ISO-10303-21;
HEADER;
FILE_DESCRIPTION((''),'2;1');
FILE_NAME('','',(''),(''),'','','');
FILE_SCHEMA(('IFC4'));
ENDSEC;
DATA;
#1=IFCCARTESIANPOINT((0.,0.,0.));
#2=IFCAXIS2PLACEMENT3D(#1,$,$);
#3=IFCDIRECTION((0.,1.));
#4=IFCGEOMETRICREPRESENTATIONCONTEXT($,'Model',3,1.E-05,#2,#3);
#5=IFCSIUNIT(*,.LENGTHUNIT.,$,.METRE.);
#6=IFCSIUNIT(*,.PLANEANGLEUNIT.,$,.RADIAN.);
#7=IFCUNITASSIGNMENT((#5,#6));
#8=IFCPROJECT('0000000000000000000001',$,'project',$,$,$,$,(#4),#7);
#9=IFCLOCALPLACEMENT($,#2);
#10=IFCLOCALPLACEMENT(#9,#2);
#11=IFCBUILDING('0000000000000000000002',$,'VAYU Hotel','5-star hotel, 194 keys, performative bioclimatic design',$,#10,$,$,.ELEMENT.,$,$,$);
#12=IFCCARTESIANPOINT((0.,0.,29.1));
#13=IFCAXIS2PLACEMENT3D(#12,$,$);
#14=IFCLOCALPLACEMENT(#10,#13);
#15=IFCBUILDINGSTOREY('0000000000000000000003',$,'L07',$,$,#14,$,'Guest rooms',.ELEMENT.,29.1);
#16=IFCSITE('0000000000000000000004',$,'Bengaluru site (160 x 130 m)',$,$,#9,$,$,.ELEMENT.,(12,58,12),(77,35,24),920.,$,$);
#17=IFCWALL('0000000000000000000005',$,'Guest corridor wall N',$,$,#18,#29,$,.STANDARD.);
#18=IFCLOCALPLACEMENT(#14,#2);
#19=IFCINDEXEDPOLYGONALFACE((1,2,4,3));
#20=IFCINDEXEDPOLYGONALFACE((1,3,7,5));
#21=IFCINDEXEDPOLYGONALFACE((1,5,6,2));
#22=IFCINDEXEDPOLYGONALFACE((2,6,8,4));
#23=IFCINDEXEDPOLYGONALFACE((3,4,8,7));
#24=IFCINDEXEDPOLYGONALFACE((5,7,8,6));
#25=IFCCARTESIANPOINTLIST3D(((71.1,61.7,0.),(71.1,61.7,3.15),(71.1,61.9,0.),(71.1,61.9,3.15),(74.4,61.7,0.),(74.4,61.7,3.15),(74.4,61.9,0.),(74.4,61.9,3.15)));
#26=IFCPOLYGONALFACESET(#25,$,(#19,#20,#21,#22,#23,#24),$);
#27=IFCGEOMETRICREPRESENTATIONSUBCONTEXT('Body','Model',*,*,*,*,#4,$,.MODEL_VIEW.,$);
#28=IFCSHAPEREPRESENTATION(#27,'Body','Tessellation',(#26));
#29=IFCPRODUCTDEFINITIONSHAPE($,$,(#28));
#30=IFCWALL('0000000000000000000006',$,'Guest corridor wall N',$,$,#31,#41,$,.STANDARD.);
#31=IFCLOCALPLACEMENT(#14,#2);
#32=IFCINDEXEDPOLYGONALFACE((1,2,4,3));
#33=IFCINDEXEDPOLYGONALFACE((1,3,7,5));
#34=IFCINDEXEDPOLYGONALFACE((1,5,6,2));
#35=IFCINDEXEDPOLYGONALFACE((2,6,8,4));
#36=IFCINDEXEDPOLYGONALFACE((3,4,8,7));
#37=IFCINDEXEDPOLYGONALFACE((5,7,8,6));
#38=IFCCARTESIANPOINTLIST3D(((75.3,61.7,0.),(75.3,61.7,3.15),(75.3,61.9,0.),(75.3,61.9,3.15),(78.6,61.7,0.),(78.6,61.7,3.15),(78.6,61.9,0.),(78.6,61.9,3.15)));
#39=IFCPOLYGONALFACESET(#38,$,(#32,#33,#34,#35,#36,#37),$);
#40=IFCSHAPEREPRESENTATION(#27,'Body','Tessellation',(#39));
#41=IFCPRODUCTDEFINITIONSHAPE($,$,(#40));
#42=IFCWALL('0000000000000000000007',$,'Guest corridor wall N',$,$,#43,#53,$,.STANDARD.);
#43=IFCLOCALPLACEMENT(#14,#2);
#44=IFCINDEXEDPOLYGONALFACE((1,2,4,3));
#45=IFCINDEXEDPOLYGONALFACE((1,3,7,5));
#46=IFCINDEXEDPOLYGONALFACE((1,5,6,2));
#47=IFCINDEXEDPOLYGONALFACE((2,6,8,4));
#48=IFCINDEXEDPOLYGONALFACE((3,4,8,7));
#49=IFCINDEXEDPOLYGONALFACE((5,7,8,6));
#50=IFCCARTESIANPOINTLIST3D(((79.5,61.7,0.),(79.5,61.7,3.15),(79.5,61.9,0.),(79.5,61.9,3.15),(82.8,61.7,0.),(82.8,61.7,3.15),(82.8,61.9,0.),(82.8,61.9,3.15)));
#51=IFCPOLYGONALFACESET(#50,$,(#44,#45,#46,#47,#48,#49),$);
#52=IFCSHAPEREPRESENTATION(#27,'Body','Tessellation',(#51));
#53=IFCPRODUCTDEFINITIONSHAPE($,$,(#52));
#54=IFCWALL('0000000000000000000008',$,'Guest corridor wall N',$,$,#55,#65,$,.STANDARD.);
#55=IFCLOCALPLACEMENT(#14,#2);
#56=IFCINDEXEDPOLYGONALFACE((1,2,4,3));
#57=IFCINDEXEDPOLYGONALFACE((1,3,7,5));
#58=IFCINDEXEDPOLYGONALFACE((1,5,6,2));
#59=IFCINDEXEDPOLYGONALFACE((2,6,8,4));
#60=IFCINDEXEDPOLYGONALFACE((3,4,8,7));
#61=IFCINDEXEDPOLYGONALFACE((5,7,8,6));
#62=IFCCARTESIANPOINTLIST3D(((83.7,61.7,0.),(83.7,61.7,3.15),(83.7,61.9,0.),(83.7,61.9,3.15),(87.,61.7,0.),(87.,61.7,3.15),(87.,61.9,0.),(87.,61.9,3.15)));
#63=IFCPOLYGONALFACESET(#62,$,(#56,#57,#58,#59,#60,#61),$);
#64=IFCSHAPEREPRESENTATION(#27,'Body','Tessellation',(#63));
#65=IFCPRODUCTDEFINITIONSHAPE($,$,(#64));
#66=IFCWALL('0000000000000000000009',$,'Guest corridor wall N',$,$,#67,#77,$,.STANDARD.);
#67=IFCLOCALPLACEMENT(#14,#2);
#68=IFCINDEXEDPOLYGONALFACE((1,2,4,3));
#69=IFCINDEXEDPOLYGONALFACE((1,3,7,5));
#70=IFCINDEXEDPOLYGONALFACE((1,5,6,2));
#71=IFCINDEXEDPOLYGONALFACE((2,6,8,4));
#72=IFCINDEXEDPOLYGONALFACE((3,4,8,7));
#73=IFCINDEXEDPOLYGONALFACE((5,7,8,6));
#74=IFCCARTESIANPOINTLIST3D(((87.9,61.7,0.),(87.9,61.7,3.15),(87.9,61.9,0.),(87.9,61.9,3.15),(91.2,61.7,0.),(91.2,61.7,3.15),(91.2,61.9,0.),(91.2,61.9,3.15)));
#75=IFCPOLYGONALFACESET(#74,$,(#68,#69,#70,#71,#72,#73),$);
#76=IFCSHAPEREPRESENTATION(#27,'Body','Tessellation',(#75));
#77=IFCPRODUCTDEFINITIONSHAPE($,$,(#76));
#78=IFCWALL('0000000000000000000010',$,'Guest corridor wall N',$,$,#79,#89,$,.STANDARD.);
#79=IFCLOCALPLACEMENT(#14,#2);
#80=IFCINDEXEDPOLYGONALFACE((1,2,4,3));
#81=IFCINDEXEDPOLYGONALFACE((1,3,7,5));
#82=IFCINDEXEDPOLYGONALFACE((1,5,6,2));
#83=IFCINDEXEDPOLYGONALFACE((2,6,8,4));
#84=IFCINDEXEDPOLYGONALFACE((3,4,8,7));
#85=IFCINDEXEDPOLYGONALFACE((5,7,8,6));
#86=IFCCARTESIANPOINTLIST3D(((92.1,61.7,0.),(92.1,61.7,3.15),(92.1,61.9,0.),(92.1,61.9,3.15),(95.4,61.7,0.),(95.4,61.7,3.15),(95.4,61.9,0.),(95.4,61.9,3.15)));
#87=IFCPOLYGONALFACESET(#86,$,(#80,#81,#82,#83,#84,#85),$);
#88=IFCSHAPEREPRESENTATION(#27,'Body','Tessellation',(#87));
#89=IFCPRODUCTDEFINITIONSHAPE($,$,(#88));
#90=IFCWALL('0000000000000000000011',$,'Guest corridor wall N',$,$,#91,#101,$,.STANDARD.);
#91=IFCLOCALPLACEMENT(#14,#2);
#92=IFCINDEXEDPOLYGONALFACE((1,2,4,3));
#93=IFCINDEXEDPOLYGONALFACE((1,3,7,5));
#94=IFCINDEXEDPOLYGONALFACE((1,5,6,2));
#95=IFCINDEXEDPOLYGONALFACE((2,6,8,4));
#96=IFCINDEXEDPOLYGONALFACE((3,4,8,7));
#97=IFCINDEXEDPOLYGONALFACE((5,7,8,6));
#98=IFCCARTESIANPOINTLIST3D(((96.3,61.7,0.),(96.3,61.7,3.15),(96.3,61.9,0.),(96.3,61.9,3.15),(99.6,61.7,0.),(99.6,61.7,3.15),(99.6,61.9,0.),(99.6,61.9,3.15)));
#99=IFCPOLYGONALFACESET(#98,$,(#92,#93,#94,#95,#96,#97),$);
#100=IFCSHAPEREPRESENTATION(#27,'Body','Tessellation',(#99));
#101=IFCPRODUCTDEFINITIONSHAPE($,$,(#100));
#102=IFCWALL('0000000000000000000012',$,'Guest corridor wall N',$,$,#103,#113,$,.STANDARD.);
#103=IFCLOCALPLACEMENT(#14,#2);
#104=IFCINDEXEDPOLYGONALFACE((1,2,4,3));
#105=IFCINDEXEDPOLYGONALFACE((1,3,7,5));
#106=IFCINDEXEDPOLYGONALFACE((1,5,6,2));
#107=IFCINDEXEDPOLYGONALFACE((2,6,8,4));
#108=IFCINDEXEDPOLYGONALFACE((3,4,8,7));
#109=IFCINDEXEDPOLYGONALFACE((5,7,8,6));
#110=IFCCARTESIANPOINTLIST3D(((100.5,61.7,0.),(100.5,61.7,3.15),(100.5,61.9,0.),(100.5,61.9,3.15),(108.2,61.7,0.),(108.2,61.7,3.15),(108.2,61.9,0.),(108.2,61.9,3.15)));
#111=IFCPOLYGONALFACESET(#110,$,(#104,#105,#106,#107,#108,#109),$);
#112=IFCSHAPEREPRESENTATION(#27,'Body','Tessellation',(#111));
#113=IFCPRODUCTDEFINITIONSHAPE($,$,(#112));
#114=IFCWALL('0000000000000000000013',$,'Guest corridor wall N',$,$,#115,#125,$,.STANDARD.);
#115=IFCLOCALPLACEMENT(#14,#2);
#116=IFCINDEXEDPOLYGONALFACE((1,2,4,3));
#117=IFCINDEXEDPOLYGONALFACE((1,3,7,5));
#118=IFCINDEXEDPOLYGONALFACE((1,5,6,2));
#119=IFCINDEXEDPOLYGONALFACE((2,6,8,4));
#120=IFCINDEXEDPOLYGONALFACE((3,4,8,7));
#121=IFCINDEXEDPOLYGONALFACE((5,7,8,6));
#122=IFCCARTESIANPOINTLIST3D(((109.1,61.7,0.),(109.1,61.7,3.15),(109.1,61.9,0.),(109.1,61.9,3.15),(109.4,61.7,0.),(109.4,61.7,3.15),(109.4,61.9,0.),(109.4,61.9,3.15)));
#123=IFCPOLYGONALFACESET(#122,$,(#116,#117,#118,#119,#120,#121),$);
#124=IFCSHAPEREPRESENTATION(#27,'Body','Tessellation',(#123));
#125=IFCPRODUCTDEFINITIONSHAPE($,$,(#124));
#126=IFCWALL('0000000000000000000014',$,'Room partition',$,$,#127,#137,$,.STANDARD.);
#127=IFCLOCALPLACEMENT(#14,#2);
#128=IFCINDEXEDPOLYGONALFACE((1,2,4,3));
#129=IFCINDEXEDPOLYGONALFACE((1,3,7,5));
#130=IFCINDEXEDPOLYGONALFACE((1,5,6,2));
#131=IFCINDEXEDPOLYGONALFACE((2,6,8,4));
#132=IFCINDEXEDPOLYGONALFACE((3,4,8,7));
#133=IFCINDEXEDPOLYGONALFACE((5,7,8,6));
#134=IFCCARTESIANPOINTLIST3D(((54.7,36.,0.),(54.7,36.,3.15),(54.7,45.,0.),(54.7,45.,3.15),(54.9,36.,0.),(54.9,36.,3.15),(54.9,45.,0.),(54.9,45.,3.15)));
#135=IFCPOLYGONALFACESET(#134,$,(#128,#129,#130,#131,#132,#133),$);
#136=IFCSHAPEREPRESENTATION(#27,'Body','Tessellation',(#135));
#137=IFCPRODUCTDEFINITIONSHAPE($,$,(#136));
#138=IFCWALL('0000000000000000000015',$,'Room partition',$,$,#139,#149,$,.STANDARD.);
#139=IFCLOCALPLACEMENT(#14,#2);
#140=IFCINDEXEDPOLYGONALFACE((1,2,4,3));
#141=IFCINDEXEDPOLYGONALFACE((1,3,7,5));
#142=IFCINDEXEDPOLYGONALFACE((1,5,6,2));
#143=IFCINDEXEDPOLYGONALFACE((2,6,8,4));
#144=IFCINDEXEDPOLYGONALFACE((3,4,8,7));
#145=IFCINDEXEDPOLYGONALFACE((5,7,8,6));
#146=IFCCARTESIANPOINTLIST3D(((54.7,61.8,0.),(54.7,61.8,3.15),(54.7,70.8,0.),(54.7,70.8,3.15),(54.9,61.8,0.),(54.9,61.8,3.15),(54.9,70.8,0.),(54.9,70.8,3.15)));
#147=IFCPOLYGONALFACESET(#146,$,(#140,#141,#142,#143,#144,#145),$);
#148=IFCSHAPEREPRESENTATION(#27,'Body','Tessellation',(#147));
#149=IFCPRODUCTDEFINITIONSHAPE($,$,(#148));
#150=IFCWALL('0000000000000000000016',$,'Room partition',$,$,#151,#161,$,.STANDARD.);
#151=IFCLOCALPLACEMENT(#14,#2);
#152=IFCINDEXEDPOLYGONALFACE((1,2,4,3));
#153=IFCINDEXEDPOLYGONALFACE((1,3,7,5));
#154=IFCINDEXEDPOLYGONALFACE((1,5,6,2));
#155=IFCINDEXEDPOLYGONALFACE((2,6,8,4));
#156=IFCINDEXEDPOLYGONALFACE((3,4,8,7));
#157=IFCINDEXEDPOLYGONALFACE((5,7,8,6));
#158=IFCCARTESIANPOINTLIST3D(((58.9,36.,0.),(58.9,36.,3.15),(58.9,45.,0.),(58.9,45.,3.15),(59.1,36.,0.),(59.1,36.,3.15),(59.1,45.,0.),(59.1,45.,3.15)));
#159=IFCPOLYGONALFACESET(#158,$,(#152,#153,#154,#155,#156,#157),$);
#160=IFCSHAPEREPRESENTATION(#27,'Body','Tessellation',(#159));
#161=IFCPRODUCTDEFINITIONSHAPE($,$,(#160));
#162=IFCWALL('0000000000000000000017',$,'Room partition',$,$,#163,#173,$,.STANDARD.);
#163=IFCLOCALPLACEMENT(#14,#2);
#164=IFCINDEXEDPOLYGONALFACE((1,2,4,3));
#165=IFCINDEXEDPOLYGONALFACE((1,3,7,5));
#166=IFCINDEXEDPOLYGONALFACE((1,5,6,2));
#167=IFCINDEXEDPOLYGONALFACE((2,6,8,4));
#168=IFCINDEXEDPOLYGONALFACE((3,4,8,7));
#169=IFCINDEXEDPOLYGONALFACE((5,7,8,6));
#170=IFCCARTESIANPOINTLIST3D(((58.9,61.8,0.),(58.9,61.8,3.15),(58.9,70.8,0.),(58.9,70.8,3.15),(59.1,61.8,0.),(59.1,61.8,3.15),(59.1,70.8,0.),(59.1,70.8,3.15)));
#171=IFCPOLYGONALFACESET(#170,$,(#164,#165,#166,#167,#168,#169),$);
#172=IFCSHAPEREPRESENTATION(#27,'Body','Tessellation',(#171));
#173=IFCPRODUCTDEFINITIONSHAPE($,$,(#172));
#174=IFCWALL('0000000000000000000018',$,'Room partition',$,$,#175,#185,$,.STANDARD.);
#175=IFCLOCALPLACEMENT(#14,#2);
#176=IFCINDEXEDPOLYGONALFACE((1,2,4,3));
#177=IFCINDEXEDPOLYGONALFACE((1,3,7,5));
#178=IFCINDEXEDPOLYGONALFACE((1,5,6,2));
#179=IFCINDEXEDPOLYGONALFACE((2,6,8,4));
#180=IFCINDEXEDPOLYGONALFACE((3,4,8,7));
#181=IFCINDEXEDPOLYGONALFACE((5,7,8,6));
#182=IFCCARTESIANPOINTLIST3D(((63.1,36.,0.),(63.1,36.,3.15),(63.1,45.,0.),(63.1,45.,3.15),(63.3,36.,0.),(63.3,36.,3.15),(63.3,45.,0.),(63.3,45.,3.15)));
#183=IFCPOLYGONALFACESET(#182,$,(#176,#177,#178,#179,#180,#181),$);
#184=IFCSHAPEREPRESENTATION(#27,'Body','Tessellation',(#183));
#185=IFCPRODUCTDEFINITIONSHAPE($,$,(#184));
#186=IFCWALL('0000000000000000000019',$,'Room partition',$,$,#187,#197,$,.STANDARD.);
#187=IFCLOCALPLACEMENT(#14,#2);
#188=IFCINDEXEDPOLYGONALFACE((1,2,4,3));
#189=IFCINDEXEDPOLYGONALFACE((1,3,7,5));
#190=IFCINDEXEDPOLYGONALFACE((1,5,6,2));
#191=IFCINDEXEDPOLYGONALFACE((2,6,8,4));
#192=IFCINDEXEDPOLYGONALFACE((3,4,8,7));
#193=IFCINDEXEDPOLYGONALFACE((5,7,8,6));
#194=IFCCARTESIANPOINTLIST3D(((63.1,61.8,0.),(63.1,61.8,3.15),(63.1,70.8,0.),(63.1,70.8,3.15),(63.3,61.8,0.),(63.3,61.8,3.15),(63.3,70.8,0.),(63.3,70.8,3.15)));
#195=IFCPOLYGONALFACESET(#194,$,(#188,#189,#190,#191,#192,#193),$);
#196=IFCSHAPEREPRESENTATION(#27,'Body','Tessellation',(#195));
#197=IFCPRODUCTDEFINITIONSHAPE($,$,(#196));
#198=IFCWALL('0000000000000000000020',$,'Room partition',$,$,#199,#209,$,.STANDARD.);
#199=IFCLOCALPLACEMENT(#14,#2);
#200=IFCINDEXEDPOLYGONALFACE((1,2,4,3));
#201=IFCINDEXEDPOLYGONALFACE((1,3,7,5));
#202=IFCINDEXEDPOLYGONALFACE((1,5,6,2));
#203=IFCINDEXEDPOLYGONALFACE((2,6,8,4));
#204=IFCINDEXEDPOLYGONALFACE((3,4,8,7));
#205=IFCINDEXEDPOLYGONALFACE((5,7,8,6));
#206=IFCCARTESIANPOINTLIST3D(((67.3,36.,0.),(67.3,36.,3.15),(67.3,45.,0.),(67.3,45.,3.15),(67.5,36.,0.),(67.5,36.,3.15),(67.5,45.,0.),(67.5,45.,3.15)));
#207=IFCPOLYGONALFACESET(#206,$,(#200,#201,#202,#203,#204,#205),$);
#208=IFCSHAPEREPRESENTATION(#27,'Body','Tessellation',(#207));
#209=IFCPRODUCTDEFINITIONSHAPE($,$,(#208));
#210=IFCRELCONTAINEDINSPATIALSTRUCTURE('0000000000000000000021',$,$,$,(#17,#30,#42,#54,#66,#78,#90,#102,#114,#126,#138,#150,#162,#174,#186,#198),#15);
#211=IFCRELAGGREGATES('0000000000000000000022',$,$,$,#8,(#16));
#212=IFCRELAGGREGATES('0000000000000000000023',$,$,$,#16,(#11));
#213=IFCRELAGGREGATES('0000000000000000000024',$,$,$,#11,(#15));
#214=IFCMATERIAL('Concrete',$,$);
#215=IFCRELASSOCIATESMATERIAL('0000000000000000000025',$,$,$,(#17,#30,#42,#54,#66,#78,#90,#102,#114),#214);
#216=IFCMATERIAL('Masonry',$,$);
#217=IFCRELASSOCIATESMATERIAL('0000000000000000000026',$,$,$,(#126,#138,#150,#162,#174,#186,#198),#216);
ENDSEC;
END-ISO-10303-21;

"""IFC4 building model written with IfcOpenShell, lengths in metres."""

from ifc_helpers import new_model, si_unit, direction, frame, origin, place, context, subcontext, project, spatial, polyline, outline, extrude, material, element, save


model = new_model("IFC4")

# Units and contexts
model_context = context("Model", 3, precision=1e-05, world=origin(), true_north=direction((0.0, 1.0)))
body_context = subcontext(model_context, "Body", "Model", "MODEL_VIEW")
ifc_project = project(units=[si_unit("LENGTHUNIT", "METRE"), si_unit("PLANEANGLEUNIT", "RADIAN")], contexts=[model_context])

# Site, building, storey
site_placement = place(None, origin())
site = spatial("IfcSite", under=ifc_project, at=site_placement, Name="Bengaluru site (160 x 130 m)", CompositionType="ELEMENT", RefLatitude=(12, 58, 12), RefLongitude=(77, 35, 24), RefElevation=920.0)
building_placement = place(site_placement, origin())
building = spatial("IfcBuilding", under=site, at=building_placement, Name="VAYU Hotel", Description="5-star hotel, 194 keys, performative bioclimatic design", CompositionType="ELEMENT")
storey_placement = place(building_placement, frame((0.0, 0.0, 29.1)))
storey = spatial("IfcBuildingStorey", under=building, at=storey_placement, Name="L07", LongName="Guest rooms", CompositionType="ELEMENT", Elevation=29.1)

# Walls
ifc_material_1 = material(Name="Concrete")
wall_1_placement = place(storey_placement, origin())
element("IfcWall", 1, at=wall_1_placement, inside=storey, material=ifc_material_1, Name="Guest corridor wall N", PredefinedType="STANDARD", context=body_context, shape_type="SweptSolid", body=[
    extrude(outline(polyline([(71.1, 61.9), (74.4, 61.9), (74.4, 61.7), (71.1, 61.7), (71.1, 61.9)])), origin(), (0.0, 0.0, 1.0), 3.15),
])
wall_2_placement = place(storey_placement, origin())
element("IfcWall", 2, at=wall_2_placement, inside=storey, material=ifc_material_1, Name="Guest corridor wall N", PredefinedType="STANDARD", context=body_context, shape_type="SweptSolid", body=[
    extrude(outline(polyline([(75.3, 61.9), (78.6, 61.9), (78.6, 61.7), (75.3, 61.7), (75.3, 61.9)])), origin(), (0.0, 0.0, 1.0), 3.15),
])
wall_3_placement = place(storey_placement, origin())
element("IfcWall", 3, at=wall_3_placement, inside=storey, material=ifc_material_1, Name="Guest corridor wall N", PredefinedType="STANDARD", context=body_context, shape_type="SweptSolid", body=[
    extrude(outline(polyline([(79.5, 61.9), (82.8, 61.9), (82.8, 61.7), (79.5, 61.7), (79.5, 61.9)])), origin(), (0.0, 0.0, 1.0), 3.15),
])
wall_4_placement = place(storey_placement, origin())
element("IfcWall", 4, at=wall_4_placement, inside=storey, material=ifc_material_1, Name="Guest corridor wall N", PredefinedType="STANDARD", context=body_context, shape_type="SweptSolid", body=[
    extrude(outline(polyline([(83.7, 61.9), (87.0, 61.9), (87.0, 61.7), (83.7, 61.7), (83.7, 61.9)])), origin(), (0.0, 0.0, 1.0), 3.15),
])
wall_5_placement = place(storey_placement, origin())
element("IfcWall", 5, at=wall_5_placement, inside=storey, material=ifc_material_1, Name="Guest corridor wall N", PredefinedType="STANDARD", context=body_context, shape_type="SweptSolid", body=[
    extrude(outline(polyline([(87.9, 61.9), (91.2, 61.9), (91.2, 61.7), (87.9, 61.7), (87.9, 61.9)])), origin(), (0.0, 0.0, 1.0), 3.15),
])
wall_6_placement = place(storey_placement, origin())
element("IfcWall", 6, at=wall_6_placement, inside=storey, material=ifc_material_1, Name="Guest corridor wall N", PredefinedType="STANDARD", context=body_context, shape_type="SweptSolid", body=[
    extrude(outline(polyline([(92.1, 61.9), (95.4, 61.9), (95.4, 61.7), (92.1, 61.7), (92.1, 61.9)])), origin(), (0.0, 0.0, 1.0), 3.15),
])
wall_7_placement = place(storey_placement, origin())
element("IfcWall", 7, at=wall_7_placement, inside=storey, material=ifc_material_1, Name="Guest corridor wall N", PredefinedType="STANDARD", context=body_context, shape_type="SweptSolid", body=[
    extrude(outline(polyline([(96.3, 61.9), (99.6, 61.9), (99.6, 61.7), (96.3, 61.7), (96.3, 61.9)])), origin(), (0.0, 0.0, 1.0), 3.15),
])
wall_8_placement = place(storey_placement, origin())
element("IfcWall", 8, at=wall_8_placement, inside=storey, material=ifc_material_1, Name="Guest corridor wall N", PredefinedType="STANDARD", context=body_context, shape_type="SweptSolid", body=[
    extrude(outline(polyline([(100.5, 61.9), (108.2, 61.9), (108.2, 61.7), (100.5, 61.7), (100.5, 61.9)])), origin(), (0.0, 0.0, 1.0), 3.15),
])
wall_9_placement = place(storey_placement, origin())
element("IfcWall", 9, at=wall_9_placement, inside=storey, material=ifc_material_1, Name="Guest corridor wall N", PredefinedType="STANDARD", context=body_context, shape_type="SweptSolid", body=[
    extrude(outline(polyline([(109.1, 61.9), (109.4, 61.9), (109.4, 61.7), (109.1, 61.7), (109.1, 61.9)])), origin(), (0.0, 0.0, 1.0), 3.15),
])
ifc_material_2 = material(Name="Masonry")
wall_10_placement = place(storey_placement, origin())
element("IfcWall", 10, at=wall_10_placement, inside=storey, material=ifc_material_2, Name="Room partition", PredefinedType="STANDARD", context=body_context, shape_type="SweptSolid", body=[
    extrude(outline(polyline([(54.7, 36.0), (54.7, 45.0), (54.9, 45.0), (54.9, 36.0), (54.7, 36.0)])), origin(), (0.0, 0.0, 1.0), 3.15),
])
wall_11_placement = place(storey_placement, origin())
element("IfcWall", 11, at=wall_11_placement, inside=storey, material=ifc_material_2, Name="Room partition", PredefinedType="STANDARD", context=body_context, shape_type="SweptSolid", body=[
    extrude(outline(polyline([(54.7, 61.8), (54.7, 70.8), (54.9, 70.8), (54.9, 61.8), (54.7, 61.8)])), origin(), (0.0, 0.0, 1.0), 3.15),
])
wall_12_placement = place(storey_placement, origin())
element("IfcWall", 12, at=wall_12_placement, inside=storey, material=ifc_material_2, Name="Room partition", PredefinedType="STANDARD", context=body_context, shape_type="SweptSolid", body=[
    extrude(outline(polyline([(58.9, 36.0), (58.9, 45.0), (59.1, 45.0), (59.1, 36.0), (58.9, 36.0)])), origin(), (0.0, 0.0, 1.0), 3.15),
])
wall_13_placement = place(storey_placement, origin())
element("IfcWall", 13, at=wall_13_placement, inside=storey, material=ifc_material_2, Name="Room partition", PredefinedType="STANDARD", context=body_context, shape_type="SweptSolid", body=[
    extrude(outline(polyline([(58.9, 61.8), (58.9, 70.8), (59.1, 70.8), (59.1, 61.8), (58.9, 61.8)])), origin(), (0.0, 0.0, 1.0), 3.15),
])
wall_14_placement = place(storey_placement, origin())
element("IfcWall", 14, at=wall_14_placement, inside=storey, material=ifc_material_2, Name="Room partition", PredefinedType="STANDARD", context=body_context, shape_type="SweptSolid", body=[
    extrude(outline(polyline([(63.1, 36.0), (63.1, 45.0), (63.3, 45.0), (63.3, 36.0), (63.1, 36.0)])), origin(), (0.0, 0.0, 1.0), 3.15),
])
wall_15_placement = place(storey_placement, origin())
element("IfcWall", 15, at=wall_15_placement, inside=storey, material=ifc_material_2, Name="Room partition", PredefinedType="STANDARD", context=body_context, shape_type="SweptSolid", body=[
    extrude(outline(polyline([(63.1, 61.8), (63.1, 70.8), (63.3, 70.8), (63.3, 61.8), (63.1, 61.8)])), origin(), (0.0, 0.0, 1.0), 3.15),
])
wall_16_placement = place(storey_placement, origin())
element("IfcWall", 16, at=wall_16_placement, inside=storey, material=ifc_material_2, Name="Room partition", PredefinedType="STANDARD", context=body_context, shape_type="SweptSolid", body=[
    extrude(outline(polyline([(67.3, 36.0), (67.3, 45.0), (67.5, 45.0), (67.5, 36.0), (67.3, 36.0)])), origin(), (0.0, 0.0, 1.0), 3.15),
])

save(model, "model.ifc")
